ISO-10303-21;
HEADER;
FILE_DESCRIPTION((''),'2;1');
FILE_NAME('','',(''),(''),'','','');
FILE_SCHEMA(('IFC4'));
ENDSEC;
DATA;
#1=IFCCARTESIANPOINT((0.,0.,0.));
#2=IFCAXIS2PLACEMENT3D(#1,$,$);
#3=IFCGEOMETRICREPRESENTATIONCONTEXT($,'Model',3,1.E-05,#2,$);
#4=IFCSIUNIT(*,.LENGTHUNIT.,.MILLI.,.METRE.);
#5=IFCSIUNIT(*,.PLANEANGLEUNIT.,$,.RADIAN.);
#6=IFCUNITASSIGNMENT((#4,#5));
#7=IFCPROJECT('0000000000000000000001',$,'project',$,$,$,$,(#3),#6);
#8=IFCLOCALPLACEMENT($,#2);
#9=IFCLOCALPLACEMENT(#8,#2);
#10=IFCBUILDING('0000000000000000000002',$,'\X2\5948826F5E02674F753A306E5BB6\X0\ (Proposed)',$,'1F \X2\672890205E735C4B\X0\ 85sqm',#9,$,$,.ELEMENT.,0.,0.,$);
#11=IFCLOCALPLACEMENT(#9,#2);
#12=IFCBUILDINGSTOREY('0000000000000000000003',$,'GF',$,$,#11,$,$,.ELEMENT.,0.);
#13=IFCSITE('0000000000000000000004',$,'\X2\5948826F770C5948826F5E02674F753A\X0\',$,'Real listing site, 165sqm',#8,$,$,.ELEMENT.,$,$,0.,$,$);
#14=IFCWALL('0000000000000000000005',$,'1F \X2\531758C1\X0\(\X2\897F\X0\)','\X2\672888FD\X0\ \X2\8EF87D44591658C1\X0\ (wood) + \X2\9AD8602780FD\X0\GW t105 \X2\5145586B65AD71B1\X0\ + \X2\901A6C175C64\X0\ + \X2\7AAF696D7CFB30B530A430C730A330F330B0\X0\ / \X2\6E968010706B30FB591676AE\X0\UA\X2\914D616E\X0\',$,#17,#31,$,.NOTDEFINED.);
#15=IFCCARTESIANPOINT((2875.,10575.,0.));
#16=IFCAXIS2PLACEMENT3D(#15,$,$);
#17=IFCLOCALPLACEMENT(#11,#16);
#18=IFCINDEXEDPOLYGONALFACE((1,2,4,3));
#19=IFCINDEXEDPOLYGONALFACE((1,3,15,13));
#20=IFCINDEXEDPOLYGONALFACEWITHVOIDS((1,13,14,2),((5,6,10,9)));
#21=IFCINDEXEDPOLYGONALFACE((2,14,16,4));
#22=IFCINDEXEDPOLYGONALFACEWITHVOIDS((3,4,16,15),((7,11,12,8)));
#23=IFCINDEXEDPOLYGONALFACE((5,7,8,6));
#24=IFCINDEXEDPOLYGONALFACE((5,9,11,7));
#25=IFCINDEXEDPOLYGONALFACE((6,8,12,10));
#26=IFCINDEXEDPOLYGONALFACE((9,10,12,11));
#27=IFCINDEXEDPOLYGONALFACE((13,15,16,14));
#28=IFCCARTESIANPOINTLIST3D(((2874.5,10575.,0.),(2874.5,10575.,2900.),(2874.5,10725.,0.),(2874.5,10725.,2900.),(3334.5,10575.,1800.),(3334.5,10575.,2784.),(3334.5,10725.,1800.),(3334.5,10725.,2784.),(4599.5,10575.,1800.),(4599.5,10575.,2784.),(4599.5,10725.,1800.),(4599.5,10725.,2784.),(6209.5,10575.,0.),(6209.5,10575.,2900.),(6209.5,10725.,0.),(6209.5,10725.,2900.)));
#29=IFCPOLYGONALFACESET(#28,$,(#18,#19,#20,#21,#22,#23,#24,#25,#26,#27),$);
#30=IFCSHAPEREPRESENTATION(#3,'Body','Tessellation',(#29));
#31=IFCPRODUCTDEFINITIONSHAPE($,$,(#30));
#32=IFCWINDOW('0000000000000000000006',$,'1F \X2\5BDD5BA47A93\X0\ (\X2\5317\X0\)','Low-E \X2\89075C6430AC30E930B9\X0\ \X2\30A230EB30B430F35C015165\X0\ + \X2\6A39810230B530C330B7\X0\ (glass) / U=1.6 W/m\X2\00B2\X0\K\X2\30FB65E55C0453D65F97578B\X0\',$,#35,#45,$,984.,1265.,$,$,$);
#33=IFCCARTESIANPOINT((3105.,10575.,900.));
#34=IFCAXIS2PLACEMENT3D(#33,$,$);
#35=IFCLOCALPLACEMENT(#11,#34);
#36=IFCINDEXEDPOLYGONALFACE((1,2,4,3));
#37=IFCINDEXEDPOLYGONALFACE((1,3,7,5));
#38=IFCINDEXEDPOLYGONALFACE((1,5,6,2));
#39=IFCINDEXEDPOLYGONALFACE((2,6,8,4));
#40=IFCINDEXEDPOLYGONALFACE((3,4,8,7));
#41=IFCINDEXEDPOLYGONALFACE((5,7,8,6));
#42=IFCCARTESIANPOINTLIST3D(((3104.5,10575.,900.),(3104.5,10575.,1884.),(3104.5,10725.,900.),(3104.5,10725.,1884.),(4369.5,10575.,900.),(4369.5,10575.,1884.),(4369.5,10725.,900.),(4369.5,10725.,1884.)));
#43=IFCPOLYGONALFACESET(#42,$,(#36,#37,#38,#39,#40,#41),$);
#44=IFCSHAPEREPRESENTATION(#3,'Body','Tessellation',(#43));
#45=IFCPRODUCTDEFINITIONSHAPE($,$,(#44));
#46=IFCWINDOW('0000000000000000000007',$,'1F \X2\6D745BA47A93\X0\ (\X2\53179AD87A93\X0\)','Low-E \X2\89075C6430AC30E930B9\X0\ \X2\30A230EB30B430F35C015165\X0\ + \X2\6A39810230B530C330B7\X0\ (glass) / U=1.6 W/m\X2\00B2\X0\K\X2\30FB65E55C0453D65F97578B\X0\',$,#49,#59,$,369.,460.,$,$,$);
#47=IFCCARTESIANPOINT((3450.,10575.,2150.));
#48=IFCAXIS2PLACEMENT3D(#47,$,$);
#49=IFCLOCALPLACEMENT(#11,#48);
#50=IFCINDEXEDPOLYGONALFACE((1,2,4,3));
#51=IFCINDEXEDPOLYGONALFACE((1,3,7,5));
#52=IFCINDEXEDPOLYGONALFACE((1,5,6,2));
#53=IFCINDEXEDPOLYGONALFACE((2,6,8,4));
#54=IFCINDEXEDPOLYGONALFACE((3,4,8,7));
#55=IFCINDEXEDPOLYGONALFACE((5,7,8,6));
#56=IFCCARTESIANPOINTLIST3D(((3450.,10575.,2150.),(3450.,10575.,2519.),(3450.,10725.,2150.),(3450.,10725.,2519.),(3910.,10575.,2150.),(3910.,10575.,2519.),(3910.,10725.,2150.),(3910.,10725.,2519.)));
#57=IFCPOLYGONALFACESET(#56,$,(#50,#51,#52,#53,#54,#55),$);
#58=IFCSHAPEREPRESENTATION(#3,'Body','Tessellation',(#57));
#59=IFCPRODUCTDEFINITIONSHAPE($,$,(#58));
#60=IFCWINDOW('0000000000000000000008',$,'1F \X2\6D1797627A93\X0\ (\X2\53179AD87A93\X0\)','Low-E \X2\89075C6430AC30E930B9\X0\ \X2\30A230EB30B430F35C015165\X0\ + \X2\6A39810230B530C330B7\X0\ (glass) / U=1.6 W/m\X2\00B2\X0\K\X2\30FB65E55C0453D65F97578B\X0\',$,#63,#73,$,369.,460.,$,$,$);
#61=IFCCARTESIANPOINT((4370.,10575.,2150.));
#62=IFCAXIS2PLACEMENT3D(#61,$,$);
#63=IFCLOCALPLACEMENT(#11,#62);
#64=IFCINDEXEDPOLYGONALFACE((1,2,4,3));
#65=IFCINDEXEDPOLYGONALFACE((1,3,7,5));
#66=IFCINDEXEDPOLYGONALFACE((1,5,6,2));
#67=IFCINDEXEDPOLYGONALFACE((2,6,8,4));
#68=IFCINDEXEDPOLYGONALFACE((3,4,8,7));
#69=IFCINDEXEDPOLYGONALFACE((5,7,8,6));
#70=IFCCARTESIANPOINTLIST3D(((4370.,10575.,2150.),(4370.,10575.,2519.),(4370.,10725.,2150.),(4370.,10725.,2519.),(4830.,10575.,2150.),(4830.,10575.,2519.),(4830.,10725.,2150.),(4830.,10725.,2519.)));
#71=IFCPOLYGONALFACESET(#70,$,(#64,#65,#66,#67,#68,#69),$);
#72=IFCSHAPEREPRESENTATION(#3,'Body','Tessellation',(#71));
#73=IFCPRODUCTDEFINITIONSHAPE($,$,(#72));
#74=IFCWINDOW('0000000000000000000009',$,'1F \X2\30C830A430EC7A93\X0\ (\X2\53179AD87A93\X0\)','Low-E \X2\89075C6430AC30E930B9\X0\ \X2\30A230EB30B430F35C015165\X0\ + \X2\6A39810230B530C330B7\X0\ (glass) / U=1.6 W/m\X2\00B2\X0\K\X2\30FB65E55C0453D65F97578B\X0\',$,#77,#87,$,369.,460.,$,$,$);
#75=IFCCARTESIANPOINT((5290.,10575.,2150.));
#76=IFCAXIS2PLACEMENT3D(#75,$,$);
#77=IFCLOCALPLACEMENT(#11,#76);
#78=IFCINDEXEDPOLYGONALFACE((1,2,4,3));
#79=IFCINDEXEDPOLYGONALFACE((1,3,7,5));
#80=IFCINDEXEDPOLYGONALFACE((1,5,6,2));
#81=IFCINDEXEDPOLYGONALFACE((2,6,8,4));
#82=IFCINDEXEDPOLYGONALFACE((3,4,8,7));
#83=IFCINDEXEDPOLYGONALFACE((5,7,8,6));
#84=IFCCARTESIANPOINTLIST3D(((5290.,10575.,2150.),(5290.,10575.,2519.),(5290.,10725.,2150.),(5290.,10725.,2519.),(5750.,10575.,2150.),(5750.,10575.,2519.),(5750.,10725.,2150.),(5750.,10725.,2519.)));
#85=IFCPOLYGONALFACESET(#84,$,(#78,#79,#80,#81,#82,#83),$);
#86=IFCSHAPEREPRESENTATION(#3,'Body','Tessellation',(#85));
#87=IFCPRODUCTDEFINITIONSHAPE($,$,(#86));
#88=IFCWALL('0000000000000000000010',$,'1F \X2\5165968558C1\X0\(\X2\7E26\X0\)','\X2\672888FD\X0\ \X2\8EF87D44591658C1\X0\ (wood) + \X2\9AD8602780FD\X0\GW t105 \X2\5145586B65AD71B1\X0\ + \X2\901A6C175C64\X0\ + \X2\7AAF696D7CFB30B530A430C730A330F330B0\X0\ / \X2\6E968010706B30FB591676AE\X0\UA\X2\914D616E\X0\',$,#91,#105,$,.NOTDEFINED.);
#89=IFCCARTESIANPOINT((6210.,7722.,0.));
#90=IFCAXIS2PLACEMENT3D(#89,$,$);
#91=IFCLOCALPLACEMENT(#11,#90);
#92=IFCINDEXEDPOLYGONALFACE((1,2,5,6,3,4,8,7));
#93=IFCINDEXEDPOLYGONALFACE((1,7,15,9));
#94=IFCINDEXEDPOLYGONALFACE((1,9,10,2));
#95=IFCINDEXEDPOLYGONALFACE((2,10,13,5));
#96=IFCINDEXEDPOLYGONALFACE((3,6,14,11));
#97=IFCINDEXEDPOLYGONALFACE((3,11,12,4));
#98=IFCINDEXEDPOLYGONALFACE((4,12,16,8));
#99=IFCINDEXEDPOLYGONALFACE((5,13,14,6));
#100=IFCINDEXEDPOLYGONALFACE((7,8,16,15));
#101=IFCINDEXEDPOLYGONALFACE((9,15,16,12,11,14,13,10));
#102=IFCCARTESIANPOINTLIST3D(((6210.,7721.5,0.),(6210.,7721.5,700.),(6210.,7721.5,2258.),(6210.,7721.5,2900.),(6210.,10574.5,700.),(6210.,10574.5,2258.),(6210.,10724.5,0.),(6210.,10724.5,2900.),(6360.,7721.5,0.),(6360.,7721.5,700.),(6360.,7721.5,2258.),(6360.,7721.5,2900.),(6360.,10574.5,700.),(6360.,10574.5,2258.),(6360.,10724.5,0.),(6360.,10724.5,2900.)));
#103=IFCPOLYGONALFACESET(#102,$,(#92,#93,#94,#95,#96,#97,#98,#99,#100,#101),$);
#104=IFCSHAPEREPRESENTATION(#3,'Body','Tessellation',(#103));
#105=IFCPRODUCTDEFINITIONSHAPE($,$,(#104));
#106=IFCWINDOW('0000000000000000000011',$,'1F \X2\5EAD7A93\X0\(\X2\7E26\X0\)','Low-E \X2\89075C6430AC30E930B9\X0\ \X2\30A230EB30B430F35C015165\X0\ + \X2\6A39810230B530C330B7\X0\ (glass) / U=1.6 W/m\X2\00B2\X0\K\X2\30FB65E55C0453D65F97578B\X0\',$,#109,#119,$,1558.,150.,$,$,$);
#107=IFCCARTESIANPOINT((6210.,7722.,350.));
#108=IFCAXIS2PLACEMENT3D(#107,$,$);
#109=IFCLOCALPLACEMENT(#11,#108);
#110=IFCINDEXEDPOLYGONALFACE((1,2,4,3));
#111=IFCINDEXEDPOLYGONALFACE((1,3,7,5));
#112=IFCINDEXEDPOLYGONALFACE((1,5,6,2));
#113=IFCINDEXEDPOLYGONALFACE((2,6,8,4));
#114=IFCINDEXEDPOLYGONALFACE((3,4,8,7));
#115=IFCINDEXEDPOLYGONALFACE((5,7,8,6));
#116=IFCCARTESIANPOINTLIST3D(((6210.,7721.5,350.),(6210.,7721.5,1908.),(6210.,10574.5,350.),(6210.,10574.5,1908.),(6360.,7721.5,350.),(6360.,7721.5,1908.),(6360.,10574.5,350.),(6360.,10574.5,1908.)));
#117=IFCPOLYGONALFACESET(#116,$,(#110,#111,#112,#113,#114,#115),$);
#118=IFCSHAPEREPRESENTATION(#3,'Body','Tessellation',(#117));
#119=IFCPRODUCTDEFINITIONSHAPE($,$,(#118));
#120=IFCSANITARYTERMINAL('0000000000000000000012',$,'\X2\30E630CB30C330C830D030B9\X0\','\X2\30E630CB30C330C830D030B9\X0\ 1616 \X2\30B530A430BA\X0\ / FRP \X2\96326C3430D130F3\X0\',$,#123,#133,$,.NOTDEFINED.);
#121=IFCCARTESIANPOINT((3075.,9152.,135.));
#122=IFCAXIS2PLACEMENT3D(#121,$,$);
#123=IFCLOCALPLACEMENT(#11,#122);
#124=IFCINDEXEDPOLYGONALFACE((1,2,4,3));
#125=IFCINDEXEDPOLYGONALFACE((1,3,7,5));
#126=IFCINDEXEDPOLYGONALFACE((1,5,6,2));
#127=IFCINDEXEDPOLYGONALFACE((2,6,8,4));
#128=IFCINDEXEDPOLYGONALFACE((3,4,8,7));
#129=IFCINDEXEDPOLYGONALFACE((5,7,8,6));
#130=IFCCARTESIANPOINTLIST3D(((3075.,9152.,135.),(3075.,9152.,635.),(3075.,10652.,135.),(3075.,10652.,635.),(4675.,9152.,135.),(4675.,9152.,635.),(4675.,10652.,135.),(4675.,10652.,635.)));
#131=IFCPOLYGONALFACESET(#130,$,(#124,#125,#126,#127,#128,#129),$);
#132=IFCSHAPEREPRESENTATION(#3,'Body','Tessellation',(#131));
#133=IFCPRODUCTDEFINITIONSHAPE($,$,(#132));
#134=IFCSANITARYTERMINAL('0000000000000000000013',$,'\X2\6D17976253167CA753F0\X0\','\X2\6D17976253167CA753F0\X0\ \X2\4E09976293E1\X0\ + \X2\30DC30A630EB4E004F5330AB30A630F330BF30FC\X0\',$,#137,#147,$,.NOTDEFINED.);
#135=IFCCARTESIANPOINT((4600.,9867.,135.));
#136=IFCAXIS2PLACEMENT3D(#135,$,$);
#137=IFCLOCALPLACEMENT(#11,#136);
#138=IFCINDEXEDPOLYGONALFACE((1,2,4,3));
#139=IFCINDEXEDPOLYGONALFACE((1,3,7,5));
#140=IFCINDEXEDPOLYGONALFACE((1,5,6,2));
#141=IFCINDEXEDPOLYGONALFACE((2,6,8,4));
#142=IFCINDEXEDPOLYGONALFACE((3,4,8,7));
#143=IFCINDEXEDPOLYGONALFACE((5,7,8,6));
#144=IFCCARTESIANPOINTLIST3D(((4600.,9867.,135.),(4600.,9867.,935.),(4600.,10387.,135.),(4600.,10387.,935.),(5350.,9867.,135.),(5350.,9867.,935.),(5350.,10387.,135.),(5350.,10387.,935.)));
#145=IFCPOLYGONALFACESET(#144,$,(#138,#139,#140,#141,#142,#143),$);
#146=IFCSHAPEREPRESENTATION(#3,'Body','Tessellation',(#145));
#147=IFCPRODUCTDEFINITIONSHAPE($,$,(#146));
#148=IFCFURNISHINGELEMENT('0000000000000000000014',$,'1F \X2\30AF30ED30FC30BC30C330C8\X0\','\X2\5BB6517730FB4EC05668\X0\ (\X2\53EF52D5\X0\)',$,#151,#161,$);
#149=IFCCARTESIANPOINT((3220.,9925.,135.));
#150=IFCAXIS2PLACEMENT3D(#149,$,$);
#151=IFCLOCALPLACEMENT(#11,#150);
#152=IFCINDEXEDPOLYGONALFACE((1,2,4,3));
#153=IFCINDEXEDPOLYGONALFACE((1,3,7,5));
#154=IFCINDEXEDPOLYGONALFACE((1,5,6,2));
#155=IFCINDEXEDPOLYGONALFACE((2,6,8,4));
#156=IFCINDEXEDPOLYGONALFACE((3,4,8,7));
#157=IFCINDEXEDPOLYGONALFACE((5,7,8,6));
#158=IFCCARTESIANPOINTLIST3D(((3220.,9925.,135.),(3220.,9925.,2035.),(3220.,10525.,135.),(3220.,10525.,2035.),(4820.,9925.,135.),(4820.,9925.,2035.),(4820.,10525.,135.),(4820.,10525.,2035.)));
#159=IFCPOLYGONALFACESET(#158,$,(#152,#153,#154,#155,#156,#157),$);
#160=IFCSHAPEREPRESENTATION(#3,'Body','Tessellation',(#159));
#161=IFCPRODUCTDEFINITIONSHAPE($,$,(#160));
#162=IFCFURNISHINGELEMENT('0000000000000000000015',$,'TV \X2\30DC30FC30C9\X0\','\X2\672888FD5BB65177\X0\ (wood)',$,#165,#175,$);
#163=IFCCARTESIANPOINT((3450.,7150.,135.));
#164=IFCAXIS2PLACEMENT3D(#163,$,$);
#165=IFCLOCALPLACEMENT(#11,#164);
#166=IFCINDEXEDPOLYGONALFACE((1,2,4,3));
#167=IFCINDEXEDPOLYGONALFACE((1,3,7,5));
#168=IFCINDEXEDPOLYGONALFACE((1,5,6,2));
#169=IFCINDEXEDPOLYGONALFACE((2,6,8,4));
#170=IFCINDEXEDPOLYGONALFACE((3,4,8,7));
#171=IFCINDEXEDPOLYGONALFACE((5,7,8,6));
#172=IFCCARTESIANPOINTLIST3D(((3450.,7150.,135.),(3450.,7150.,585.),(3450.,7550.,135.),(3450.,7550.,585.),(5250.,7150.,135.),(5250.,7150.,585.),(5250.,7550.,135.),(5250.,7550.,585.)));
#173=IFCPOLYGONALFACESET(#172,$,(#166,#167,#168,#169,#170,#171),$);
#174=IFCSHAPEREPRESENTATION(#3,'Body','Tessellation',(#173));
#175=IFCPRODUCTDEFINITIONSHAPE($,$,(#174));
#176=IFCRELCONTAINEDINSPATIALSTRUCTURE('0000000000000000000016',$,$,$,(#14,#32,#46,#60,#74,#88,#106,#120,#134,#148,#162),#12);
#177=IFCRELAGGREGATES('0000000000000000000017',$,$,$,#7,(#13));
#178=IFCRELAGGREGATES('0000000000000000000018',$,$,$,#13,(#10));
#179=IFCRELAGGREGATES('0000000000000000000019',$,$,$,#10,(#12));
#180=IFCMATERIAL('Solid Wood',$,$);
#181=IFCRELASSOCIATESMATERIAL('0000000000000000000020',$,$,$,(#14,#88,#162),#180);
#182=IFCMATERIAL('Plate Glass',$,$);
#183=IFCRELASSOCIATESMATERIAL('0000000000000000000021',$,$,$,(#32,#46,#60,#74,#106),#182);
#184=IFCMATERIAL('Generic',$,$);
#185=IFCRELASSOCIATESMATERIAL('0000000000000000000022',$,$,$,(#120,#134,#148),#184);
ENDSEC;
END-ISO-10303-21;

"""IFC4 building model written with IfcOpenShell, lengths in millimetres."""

from ifc_helpers import new_model, si_unit, frame, frame_2d, origin, place, context, project, spatial, rectangle, extrude, material, element, fill, save


model = new_model("IFC4")

# Units and contexts
model_context = context("Model", 3, precision=1e-05, world=origin())
ifc_project = project(units=[si_unit("LENGTHUNIT", "METRE", prefix="MILLI"), si_unit("PLANEANGLEUNIT", "RADIAN")], contexts=[model_context])

# Site, building, storey
site_placement = place(None, origin())
site = spatial("IfcSite", under=ifc_project, at=site_placement, Name="奈良県奈良市杏町", ObjectType="Real listing site, 165sqm", CompositionType="ELEMENT", RefElevation=0.0)
building_placement = place(site_placement, origin())
building = spatial("IfcBuilding", under=site, at=building_placement, Name="奈良市杏町の家 (Proposed)", ObjectType="1F 木造平屋 85sqm", CompositionType="ELEMENT", ElevationOfRefHeight=0.0, ElevationOfTerrain=0.0)
storey_placement = place(building_placement, origin())
storey = spatial("IfcBuildingStorey", under=building, at=storey_placement, Name="GF", CompositionType="ELEMENT", Elevation=0.0)

# Shared definitions
ifc_material_1 = material(Name="Solid Wood")

# Wall, openings, windows
wall_1_placement = place(storey_placement, frame((2875.0, 10575.0, 0.0)))
wall_1 = element("IfcWall", 1, at=wall_1_placement, inside=storey, material=ifc_material_1, Name="1F 北壁(西)", Description="木製 軸組外壁 (wood) + 高性能GW t105 充填断熱 + 通気層 + 窯業系サイディング / 準耐火・外皮UA配慮", PredefinedType="NOTDEFINED", context=model_context, shape_type="SweptSolid", body=[
    extrude(rectangle(XDim=3335.0, YDim=150.0, at=frame_2d((1667.0, 75.0))), frame((2875.0, 10575.0, 0.0)), (0.0, 0.0, 1.0), 2900.0),
])
opening_1_placement = place(storey_placement, frame((3105.0, 10575.0, 900.0)))
opening_1 = element("IfcOpeningElement", 2, at=opening_1_placement, cuts=wall_1, PredefinedType="NOTDEFINED", context=model_context, shape_type="SweptSolid", body=[
    extrude(rectangle(XDim=1265.0, YDim=150.0, at=frame_2d((632.0, 75.0))), frame((3105.0, 10575.0, 900.0)), (0.0, 0.0, 1.0), 984.0),
])
opening_2_placement = place(storey_placement, frame((3450.0, 10575.0, 2150.0)))
opening_2 = element("IfcOpeningElement", 3, at=opening_2_placement, cuts=wall_1, PredefinedType="NOTDEFINED", context=model_context, shape_type="SweptSolid", body=[
    extrude(rectangle(XDim=460.0, YDim=150.0, at=frame_2d((230.0, 75.0))), frame((3450.0, 10575.0, 2150.0)), (0.0, 0.0, 1.0), 369.0),
])
opening_3_placement = place(storey_placement, frame((4370.0, 10575.0, 2150.0)))
opening_3 = element("IfcOpeningElement", 4, at=opening_3_placement, cuts=wall_1, PredefinedType="NOTDEFINED", context=model_context, shape_type="SweptSolid", body=[
    extrude(rectangle(XDim=460.0, YDim=150.0, at=frame_2d((230.0, 75.0))), frame((4370.0, 10575.0, 2150.0)), (0.0, 0.0, 1.0), 369.0),
])
opening_4_placement = place(storey_placement, frame((5290.0, 10575.0, 2150.0)))
opening_4 = element("IfcOpeningElement", 5, at=opening_4_placement, cuts=wall_1, PredefinedType="NOTDEFINED", context=model_context, shape_type="SweptSolid", body=[
    extrude(rectangle(XDim=460.0, YDim=150.0, at=frame_2d((230.0, 75.0))), frame((5290.0, 10575.0, 2150.0)), (0.0, 0.0, 1.0), 369.0),
])
ifc_material_2 = material(Name="Plate Glass")
window_1_placement = place(storey_placement, frame((3105.0, 10575.0, 900.0)))
window_1 = element("IfcWindow", 6, at=window_1_placement, inside=storey, material=ifc_material_2, Name="1F 寝室窓 (北)", Description="Low-E 複層ガラス アルゴン封入 + 樹脂サッシ (glass) / U=1.6 W/m²K・日射取得型", OverallHeight=984.0, OverallWidth=1265.0, context=model_context, shape_type="SweptSolid", body=[
    extrude(rectangle(XDim=1265.0, YDim=150.0, at=frame_2d((632.0, 75.0))), frame((3105.0, 10575.0, 900.0)), (0.0, 0.0, 1.0), 984.0),
])
fill(opening_1, window_1)
window_2_placement = place(storey_placement, frame((3450.0, 10575.0, 2150.0)))
window_2 = element("IfcWindow", 7, at=window_2_placement, inside=storey, material=ifc_material_2, Name="1F 浴室窓 (北高窓)", Description="Low-E 複層ガラス アルゴン封入 + 樹脂サッシ (glass) / U=1.6 W/m²K・日射取得型", OverallHeight=369.0, OverallWidth=460.0, context=model_context, shape_type="SweptSolid", body=[
    extrude(rectangle(XDim=460.0, YDim=150.0, at=frame_2d((230.0, 75.0))), frame((3450.0, 10575.0, 2150.0)), (0.0, 0.0, 1.0), 369.0),
])
fill(opening_2, window_2)
window_3_placement = place(storey_placement, frame((4370.0, 10575.0, 2150.0)))
window_3 = element("IfcWindow", 8, at=window_3_placement, inside=storey, material=ifc_material_2, Name="1F 洗面窓 (北高窓)", Description="Low-E 複層ガラス アルゴン封入 + 樹脂サッシ (glass) / U=1.6 W/m²K・日射取得型", OverallHeight=369.0, OverallWidth=460.0, context=model_context, shape_type="SweptSolid", body=[
    extrude(rectangle(XDim=460.0, YDim=150.0, at=frame_2d((230.0, 75.0))), frame((4370.0, 10575.0, 2150.0)), (0.0, 0.0, 1.0), 369.0),
])
fill(opening_3, window_3)
window_4_placement = place(storey_placement, frame((5290.0, 10575.0, 2150.0)))
window_4 = element("IfcWindow", 9, at=window_4_placement, inside=storey, material=ifc_material_2, Name="1F トイレ窓 (北高窓)", Description="Low-E 複層ガラス アルゴン封入 + 樹脂サッシ (glass) / U=1.6 W/m²K・日射取得型", OverallHeight=369.0, OverallWidth=460.0, context=model_context, shape_type="SweptSolid", body=[
    extrude(rectangle(XDim=460.0, YDim=150.0, at=frame_2d((230.0, 75.0))), frame((5290.0, 10575.0, 2150.0)), (0.0, 0.0, 1.0), 369.0),
])
fill(opening_4, window_4)

# Wall, opening, window
wall_2_placement = place(storey_placement, frame((6210.0, 7722.0, 0.0)))
wall_2 = element("IfcWall", 10, at=wall_2_placement, inside=storey, material=ifc_material_1, Name="1F 入隅壁(縦)", Description="木製 軸組外壁 (wood) + 高性能GW t105 充填断熱 + 通気層 + 窯業系サイディング / 準耐火・外皮UA配慮", PredefinedType="NOTDEFINED", context=model_context, shape_type="SweptSolid", body=[
    extrude(rectangle(XDim=150.0, YDim=3003.0, at=frame_2d((75.0, 1501.0))), frame((6210.0, 7722.0, 0.0)), (0.0, 0.0, 1.0), 2900.0),
])
opening_5_placement = place(storey_placement, frame((6210.0, 7722.0, 350.0)))
opening_5 = element("IfcOpeningElement", 11, at=opening_5_placement, cuts=wall_2, PredefinedType="NOTDEFINED", context=model_context, shape_type="SweptSolid", body=[
    extrude(rectangle(XDim=150.0, YDim=2853.0, at=frame_2d((75.0, 1426.0))), frame((6210.0, 7722.0, 350.0)), (0.0, 0.0, 1.0), 1558.0),
])
window_5_placement = place(storey_placement, frame((6210.0, 7722.0, 350.0)))
window_5 = element("IfcWindow", 12, at=window_5_placement, inside=storey, material=ifc_material_2, Name="1F 庭窓(縦)", Description="Low-E 複層ガラス アルゴン封入 + 樹脂サッシ (glass) / U=1.6 W/m²K・日射取得型", OverallHeight=1558.0, OverallWidth=150.0, context=model_context, shape_type="SweptSolid", body=[
    extrude(rectangle(XDim=150.0, YDim=2853.0, at=frame_2d((75.0, 1426.0))), frame((6210.0, 7722.0, 350.0)), (0.0, 0.0, 1.0), 1558.0),
])
fill(opening_5, window_5)

# Shared definitions
ifc_material_3 = material(Name="Generic")

# Sanitary terminals
sanitary_terminal_1_placement = place(storey_placement, frame((3075.0, 9152.0, 135.0)))
element("IfcSanitaryTerminal", 13, at=sanitary_terminal_1_placement, inside=storey, material=ifc_material_3, Name="ユニットバス", Description="ユニットバス 1616 サイズ / FRP 防水パン", PredefinedType="NOTDEFINED", context=model_context, shape_type="SweptSolid", body=[
    extrude(rectangle(XDim=1600.0, YDim=1500.0, at=frame_2d((800.0, 750.0))), frame((3075.0, 9152.0, 135.0)), (0.0, 0.0, 1.0), 500.0),
])
sanitary_terminal_2_placement = place(storey_placement, frame((4600.0, 9867.0, 135.0)))
element("IfcSanitaryTerminal", 14, at=sanitary_terminal_2_placement, inside=storey, material=ifc_material_3, Name="洗面化粧台", Description="洗面化粧台 三面鏡 + ボウル一体カウンター", PredefinedType="NOTDEFINED", context=model_context, shape_type="SweptSolid", body=[
    extrude(rectangle(XDim=750.0, YDim=520.0, at=frame_2d((375.0, 260.0))), frame((4600.0, 9867.0, 135.0)), (0.0, 0.0, 1.0), 800.0),
])

# Furnishing elements
furnishing_1_placement = place(storey_placement, frame((3220.0, 9925.0, 135.0)))
element("IfcFurnishingElement", 15, at=furnishing_1_placement, inside=storey, material=ifc_material_3, Name="1F クローゼット", Description="家具・什器 (可動)", context=model_context, shape_type="SweptSolid", body=[
    extrude(rectangle(XDim=1600.0, YDim=600.0, at=frame_2d((800.0, 300.0))), frame((3220.0, 9925.0, 135.0)), (0.0, 0.0, 1.0), 1900.0),
])
furnishing_2_placement = place(storey_placement, frame((3450.0, 7150.0, 135.0)))
element("IfcFurnishingElement", 16, at=furnishing_2_placement, inside=storey, material=ifc_material_1, Name="TV ボード", Description="木製家具 (wood)", context=model_context, shape_type="SweptSolid", body=[
    extrude(rectangle(XDim=1800.0, YDim=400.0, at=frame_2d((900.0, 200.0))), frame((3450.0, 7150.0, 135.0)), (0.0, 0.0, 1.0), 450.0),
])

save(model, "model.ifc")
